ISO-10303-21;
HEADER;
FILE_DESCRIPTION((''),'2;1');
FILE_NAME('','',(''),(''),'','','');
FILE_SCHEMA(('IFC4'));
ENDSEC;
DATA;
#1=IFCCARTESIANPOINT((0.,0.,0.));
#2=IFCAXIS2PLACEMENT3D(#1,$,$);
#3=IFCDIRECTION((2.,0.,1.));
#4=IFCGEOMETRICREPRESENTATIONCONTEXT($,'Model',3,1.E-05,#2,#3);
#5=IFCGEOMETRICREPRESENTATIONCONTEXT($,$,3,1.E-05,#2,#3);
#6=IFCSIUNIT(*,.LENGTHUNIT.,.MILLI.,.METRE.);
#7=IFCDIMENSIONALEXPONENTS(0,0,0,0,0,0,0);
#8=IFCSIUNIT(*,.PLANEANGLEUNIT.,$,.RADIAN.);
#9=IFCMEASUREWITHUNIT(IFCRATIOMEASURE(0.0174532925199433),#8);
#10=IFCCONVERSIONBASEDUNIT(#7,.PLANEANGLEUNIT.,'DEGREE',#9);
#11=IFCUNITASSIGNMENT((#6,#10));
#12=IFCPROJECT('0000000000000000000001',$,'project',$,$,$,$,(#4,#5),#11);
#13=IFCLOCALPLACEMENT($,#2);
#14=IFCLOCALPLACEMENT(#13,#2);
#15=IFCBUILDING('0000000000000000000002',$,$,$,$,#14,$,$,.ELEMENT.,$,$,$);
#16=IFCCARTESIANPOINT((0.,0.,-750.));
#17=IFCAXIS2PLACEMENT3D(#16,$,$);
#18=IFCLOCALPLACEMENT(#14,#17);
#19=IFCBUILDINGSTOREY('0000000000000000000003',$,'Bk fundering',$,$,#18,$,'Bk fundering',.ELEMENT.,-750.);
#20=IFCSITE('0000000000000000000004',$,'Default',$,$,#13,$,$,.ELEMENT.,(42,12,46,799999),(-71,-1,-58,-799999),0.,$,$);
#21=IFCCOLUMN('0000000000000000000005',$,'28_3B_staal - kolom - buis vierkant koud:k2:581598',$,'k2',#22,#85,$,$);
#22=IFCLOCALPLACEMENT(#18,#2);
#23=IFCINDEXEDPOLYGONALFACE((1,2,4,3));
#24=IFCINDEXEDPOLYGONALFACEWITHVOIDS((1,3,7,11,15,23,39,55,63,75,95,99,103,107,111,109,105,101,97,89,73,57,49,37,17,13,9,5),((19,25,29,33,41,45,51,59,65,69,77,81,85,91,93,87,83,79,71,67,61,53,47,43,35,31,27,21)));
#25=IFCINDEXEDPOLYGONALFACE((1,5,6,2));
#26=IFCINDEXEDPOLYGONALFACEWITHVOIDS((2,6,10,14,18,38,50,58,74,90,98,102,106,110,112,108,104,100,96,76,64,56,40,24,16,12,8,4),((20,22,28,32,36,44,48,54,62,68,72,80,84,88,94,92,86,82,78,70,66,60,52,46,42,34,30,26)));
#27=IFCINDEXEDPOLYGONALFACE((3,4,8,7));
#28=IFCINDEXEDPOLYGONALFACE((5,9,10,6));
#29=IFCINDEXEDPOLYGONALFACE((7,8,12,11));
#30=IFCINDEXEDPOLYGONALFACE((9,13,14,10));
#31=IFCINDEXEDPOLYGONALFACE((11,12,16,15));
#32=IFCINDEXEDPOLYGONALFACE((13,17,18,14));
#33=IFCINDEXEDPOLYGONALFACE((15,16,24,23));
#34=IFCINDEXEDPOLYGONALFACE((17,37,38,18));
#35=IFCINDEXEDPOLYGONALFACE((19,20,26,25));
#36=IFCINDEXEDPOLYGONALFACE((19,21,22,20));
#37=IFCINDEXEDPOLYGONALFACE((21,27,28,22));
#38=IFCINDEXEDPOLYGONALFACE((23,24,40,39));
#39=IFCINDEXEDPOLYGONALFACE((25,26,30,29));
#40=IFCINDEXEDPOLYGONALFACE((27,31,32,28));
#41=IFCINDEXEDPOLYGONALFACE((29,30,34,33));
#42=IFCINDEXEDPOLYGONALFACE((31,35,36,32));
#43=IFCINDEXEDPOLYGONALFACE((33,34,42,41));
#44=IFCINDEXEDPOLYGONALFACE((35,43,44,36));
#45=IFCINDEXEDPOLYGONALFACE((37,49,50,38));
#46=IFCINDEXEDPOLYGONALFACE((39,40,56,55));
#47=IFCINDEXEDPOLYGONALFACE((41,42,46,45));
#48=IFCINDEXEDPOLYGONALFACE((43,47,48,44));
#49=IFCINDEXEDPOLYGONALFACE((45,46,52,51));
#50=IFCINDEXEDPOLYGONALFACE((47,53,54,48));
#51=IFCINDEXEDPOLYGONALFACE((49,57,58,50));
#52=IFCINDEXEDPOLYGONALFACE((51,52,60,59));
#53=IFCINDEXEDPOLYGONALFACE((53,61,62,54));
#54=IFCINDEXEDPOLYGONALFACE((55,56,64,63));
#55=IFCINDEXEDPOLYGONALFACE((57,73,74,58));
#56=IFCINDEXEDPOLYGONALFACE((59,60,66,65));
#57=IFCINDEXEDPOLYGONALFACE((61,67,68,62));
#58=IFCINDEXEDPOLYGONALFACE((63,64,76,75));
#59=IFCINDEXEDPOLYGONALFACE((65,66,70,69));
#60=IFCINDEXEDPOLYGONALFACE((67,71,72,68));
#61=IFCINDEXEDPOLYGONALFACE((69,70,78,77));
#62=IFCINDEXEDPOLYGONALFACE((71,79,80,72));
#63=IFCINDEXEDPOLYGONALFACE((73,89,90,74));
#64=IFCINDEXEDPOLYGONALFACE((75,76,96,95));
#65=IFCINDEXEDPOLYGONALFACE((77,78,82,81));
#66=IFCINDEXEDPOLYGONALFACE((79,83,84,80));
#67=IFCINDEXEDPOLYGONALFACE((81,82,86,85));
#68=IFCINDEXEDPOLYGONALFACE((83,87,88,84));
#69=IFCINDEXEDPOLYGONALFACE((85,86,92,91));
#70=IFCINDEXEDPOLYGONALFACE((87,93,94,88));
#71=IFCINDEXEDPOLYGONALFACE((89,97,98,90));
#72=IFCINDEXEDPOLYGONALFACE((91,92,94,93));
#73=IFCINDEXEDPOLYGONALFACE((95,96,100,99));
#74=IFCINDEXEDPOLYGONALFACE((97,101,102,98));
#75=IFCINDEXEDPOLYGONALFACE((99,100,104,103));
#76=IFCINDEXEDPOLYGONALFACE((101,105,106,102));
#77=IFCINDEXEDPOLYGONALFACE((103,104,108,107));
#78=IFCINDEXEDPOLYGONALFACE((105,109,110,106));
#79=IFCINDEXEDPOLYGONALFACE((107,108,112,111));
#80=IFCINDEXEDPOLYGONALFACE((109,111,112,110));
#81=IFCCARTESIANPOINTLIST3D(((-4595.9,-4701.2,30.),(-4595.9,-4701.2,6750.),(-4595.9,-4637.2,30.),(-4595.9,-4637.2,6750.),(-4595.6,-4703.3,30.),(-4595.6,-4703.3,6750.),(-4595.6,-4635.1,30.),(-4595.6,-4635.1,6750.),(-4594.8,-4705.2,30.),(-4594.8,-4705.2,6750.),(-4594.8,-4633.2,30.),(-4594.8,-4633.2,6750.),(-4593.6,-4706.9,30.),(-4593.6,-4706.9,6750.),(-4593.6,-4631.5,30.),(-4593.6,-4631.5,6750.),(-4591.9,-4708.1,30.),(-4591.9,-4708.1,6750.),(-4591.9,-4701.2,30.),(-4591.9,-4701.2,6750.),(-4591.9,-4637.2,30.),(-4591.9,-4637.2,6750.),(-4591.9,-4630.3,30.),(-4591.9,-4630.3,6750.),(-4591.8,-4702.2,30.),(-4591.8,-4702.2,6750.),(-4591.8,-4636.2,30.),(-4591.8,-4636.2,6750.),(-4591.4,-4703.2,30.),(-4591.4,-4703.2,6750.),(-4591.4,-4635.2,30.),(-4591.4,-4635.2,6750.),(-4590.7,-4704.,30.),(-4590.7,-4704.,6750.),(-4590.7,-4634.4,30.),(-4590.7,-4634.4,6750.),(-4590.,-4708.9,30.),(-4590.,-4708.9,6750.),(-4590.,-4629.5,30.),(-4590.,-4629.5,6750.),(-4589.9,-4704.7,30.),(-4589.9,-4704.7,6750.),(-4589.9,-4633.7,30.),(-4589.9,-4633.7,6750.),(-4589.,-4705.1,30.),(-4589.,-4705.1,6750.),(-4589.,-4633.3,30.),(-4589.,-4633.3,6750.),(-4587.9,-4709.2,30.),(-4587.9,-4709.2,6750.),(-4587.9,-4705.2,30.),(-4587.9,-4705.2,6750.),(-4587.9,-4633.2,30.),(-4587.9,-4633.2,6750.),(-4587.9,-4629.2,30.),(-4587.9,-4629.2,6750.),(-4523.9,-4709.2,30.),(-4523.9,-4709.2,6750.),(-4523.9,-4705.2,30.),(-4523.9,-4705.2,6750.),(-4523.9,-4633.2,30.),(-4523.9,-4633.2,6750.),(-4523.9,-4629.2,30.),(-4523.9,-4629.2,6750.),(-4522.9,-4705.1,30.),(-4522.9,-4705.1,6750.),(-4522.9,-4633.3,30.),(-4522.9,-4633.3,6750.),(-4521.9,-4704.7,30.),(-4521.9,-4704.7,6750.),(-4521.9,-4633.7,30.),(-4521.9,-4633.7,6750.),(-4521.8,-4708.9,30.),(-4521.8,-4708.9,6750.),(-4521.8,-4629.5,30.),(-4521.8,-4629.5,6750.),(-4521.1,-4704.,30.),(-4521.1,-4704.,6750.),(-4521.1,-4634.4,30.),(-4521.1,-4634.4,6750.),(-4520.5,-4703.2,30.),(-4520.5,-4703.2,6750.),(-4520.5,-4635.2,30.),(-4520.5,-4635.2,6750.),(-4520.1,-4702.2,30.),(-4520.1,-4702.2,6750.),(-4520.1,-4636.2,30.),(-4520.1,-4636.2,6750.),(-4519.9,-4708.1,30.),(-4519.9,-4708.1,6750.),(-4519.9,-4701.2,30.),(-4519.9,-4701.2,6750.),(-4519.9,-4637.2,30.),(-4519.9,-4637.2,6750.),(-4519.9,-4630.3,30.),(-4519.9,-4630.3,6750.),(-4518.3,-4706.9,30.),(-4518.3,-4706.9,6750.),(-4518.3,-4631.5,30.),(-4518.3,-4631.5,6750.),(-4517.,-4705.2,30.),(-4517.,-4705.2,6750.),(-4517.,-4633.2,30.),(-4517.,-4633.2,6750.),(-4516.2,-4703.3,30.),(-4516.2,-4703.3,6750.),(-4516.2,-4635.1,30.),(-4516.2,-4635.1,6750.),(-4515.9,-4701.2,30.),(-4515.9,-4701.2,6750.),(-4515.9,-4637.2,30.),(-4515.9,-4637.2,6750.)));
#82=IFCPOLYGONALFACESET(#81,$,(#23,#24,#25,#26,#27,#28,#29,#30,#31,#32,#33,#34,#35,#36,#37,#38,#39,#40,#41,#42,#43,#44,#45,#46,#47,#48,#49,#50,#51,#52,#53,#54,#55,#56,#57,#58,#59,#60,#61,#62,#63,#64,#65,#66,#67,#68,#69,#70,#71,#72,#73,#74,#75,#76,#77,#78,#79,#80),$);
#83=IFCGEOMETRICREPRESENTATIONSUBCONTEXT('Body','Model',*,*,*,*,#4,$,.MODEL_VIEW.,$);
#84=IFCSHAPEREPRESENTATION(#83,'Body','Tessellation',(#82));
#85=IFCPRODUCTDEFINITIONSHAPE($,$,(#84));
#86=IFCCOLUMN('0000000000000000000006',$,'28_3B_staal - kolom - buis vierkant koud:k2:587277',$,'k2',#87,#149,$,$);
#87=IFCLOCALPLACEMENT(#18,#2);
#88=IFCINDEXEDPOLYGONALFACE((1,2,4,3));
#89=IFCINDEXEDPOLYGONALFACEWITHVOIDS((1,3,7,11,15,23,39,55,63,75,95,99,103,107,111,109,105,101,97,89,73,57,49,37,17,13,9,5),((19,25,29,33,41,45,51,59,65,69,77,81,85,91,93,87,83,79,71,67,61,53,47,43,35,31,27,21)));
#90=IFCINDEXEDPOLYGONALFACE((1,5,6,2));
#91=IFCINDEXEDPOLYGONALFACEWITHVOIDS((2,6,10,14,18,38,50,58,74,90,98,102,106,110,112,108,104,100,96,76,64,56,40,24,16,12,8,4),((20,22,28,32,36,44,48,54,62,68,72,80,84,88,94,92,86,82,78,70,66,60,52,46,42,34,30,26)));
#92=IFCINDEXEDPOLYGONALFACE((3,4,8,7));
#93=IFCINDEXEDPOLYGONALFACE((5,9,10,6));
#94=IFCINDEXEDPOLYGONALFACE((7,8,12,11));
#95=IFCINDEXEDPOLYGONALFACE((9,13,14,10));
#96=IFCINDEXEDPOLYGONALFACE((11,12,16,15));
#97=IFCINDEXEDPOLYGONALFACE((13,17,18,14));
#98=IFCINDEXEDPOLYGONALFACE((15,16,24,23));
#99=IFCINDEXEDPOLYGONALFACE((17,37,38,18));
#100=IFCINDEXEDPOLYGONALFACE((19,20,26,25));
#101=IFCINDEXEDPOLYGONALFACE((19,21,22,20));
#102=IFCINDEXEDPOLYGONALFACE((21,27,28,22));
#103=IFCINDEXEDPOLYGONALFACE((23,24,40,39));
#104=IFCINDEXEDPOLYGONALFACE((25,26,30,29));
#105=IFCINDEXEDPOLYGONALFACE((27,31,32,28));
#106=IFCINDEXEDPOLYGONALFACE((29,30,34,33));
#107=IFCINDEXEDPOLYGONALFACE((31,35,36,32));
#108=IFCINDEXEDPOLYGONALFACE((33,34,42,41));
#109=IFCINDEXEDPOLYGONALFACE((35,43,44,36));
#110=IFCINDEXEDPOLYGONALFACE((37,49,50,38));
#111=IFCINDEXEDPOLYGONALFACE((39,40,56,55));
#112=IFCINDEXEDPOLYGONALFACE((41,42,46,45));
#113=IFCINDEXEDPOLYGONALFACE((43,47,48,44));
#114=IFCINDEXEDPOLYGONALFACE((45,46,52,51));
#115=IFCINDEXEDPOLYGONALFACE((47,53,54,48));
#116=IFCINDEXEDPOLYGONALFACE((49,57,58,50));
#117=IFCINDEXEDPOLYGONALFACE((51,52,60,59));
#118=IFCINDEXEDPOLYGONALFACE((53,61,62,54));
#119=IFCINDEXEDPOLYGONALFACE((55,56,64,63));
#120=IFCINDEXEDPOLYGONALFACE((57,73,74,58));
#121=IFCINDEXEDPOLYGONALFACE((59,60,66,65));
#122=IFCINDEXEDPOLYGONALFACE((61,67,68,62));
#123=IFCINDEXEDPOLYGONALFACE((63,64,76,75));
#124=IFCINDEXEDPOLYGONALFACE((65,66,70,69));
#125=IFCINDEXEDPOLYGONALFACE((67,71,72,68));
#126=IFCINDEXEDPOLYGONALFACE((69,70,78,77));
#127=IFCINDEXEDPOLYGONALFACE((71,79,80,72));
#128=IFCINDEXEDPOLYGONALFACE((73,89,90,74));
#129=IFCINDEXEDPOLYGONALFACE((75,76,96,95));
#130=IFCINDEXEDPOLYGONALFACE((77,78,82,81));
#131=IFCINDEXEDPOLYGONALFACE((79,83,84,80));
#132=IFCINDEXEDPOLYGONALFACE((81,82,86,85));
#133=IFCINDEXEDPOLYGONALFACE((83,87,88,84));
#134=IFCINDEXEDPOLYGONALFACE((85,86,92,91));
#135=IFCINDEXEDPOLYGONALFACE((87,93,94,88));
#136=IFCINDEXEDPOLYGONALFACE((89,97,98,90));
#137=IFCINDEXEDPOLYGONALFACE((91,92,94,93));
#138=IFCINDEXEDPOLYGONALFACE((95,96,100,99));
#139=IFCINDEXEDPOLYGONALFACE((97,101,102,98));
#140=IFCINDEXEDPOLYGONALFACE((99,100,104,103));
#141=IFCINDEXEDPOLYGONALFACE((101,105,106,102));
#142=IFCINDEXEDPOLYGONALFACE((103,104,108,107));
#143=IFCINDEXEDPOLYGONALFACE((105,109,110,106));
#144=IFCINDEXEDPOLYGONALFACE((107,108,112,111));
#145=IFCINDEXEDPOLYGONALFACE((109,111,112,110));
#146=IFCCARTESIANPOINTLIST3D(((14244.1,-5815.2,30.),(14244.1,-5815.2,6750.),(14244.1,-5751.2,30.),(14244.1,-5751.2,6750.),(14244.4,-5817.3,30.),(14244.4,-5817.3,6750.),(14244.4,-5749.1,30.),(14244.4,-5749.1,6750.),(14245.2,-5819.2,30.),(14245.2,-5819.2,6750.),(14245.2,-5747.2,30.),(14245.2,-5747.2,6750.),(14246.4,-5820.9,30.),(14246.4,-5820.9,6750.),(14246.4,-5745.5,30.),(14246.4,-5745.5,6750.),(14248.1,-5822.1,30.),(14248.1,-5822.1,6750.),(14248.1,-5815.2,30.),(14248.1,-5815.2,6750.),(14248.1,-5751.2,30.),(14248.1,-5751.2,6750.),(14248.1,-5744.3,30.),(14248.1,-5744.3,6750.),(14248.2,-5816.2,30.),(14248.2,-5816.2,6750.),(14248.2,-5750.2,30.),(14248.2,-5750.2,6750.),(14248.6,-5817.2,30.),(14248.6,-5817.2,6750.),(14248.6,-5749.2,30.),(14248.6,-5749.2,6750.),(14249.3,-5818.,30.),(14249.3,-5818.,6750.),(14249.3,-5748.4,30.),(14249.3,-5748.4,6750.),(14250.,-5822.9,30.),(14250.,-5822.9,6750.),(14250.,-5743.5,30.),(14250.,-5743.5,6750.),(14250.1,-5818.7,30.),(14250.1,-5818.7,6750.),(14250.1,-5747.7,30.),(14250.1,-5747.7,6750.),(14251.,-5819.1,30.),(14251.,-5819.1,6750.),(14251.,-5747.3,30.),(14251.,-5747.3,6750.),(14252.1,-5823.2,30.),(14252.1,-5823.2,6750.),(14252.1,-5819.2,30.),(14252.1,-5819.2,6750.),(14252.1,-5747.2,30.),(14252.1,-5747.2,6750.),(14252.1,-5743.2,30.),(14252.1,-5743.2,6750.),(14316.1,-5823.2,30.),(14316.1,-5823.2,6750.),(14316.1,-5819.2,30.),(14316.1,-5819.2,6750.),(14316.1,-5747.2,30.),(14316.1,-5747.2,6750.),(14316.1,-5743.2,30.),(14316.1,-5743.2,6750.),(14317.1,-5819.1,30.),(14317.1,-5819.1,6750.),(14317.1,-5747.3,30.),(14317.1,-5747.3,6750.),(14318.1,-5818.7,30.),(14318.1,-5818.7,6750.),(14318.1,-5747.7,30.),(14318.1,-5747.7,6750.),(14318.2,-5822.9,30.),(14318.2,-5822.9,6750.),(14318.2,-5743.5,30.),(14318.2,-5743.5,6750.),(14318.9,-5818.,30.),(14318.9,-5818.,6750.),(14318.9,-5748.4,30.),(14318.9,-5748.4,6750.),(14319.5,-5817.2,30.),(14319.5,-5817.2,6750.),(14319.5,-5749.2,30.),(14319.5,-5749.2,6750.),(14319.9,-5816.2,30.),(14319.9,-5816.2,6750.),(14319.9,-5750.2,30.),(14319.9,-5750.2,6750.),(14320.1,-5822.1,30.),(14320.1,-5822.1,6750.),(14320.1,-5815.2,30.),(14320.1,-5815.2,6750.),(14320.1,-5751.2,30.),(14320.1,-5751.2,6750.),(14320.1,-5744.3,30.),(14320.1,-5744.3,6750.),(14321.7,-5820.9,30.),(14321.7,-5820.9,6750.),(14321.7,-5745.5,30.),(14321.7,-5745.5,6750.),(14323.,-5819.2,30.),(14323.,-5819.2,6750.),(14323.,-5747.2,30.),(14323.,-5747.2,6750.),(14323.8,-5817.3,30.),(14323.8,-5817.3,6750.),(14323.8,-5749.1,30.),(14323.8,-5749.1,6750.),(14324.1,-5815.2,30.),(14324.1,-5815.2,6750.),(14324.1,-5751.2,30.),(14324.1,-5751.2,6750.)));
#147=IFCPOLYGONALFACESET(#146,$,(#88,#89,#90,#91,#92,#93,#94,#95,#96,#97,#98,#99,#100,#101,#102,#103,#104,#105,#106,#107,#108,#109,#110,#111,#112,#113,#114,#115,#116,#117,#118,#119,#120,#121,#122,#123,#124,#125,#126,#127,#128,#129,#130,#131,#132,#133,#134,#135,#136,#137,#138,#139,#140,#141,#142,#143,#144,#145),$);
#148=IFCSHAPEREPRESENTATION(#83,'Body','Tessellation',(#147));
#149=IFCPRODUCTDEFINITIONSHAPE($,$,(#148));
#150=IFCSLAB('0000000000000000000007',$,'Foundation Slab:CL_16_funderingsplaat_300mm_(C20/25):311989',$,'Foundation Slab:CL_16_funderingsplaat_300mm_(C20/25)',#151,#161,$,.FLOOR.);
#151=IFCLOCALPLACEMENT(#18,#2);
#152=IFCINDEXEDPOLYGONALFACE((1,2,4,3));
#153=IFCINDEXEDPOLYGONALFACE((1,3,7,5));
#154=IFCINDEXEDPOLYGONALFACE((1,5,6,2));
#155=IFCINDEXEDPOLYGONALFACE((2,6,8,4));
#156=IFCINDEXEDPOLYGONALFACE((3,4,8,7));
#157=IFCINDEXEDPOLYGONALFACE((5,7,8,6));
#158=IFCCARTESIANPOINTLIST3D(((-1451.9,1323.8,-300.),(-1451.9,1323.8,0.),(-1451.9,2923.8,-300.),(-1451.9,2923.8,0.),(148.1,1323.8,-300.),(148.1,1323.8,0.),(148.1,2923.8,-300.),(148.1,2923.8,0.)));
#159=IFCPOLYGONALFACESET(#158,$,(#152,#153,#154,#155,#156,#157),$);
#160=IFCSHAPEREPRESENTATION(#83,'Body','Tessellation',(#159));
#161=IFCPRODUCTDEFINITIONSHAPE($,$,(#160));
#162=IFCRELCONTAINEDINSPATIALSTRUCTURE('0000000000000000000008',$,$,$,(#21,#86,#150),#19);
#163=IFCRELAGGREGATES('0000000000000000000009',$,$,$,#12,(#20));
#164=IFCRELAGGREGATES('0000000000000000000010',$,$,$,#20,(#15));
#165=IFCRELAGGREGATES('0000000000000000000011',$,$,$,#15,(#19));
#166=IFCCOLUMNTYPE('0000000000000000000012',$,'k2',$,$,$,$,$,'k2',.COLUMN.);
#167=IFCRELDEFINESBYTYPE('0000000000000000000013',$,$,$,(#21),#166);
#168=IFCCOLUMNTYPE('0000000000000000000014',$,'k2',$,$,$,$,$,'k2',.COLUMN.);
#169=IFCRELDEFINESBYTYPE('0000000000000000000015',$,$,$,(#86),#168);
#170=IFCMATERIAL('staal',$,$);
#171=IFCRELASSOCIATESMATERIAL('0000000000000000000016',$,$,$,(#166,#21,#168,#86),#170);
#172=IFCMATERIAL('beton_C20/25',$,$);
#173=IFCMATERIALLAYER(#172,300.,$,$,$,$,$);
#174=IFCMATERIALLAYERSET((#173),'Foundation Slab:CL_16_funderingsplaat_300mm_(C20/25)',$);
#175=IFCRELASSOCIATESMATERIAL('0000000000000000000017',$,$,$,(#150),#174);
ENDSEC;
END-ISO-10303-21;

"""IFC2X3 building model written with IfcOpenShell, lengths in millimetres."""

from ifc_helpers import new_model, entity, si_unit, converted_unit, direction, frame, frame_2d, origin, place, context, subcontext, project, spatial, polyline, circle_curve, parameter, trimmed, segment, composite_curve, rectangle, outline, extrude, source, transform, mapped, material, layer, layer_set, layer_usage, type_object, type_shapes, element, save


model = new_model("IFC2X3")

# Units and contexts
model_context = context("Model", 3, precision=1e-05, world=origin(), true_north=direction((2.0, 0.0, 1.0)))
context_of_model = context(None, 3, precision=1e-05, world=origin(), true_north=direction((2.0, 0.0, 1.0)))
body_context = subcontext(model_context, "Body", "Model", "MODEL_VIEW")
ifc_project = project(units=[si_unit("LENGTHUNIT", "METRE", prefix="MILLI"), converted_unit("PLANEANGLEUNIT", "DEGREE", entity("IfcRatioMeasure", 0.0174532925199433), si_unit("PLANEANGLEUNIT", "RADIAN"), dimensions=[0, 0, 0, 0, 0, 0, 0])], contexts=[model_context, context_of_model])

# Site, building, storey
site_placement = place(None, origin())
site = spatial("IfcSite", under=ifc_project, at=site_placement, Name="Default", CompositionType="ELEMENT", RefLatitude=(42, 12, 46, 799999), RefLongitude=(-71, -1, -58, -799999), RefElevation=0.0)
building_placement = place(site_placement, origin())
building = spatial("IfcBuilding", under=site, at=building_placement, CompositionType="ELEMENT")
storey_placement = place(building_placement, frame((0.0, 0.0, -750.0)))
storey = spatial("IfcBuildingStorey", under=building, at=storey_placement, Name="Bk fundering", LongName="Bk fundering", CompositionType="ELEMENT", Elevation=-750.0)

# Columns
ifc_material_1 = material(Name="staal")
column_type_1 = type_object("IfcColumnType", Name="k2", ElementType="k2", PredefinedType="COLUMN", material=ifc_material_1)
shared_shape_1 = source(origin(), body_context, "Body", "SweptSolid", [
    extrude(outline(composite_curve([segment(trimmed(circle_curve(frame_2d((32.0, -32.0), x_axis=(1.0, 0.0)), 8.0), [parameter(270.0)], [parameter(0.0)], True, "PARAMETER"), True, "CONTINUOUS"), segment(polyline([(40.0, -32.0), (40.0, 32.0)]), True, "CONTINUOUS"), segment(trimmed(circle_curve(frame_2d((32.0, 32.0), x_axis=(1.0, 0.0)), 8.0), [parameter(0.0)], [parameter(90.0)], True, "PARAMETER"), True, "CONTINUOUS"), segment(polyline([(32.0, 40.0), (-32.0, 40.0)]), True, "CONTINUOUS"), segment(trimmed(circle_curve(frame_2d((-32.0, 32.0), x_axis=(1.0, 0.0)), 8.0), [parameter(90.0)], [parameter(180.0)], True, "PARAMETER"), True, "CONTINUOUS"), segment(polyline([(-40.0, 32.0), (-40.0, -32.0)]), True, "CONTINUOUS"), segment(trimmed(circle_curve(frame_2d((-32.0, -32.0), x_axis=(1.0, 0.0)), 8.0), [parameter(180.0)], [parameter(270.0)], True, "PARAMETER"), True, "CONTINUOUS"), segment(polyline([(-32.0, -40.0), (32.0, -40.0)]), True, "CONTINUOUS")], self_intersect=False), holes=[composite_curve([segment(polyline([(32.0, -36.0), (-32.0, -36.0)]), True, "CONTINUOUS"), segment(trimmed(circle_curve(frame_2d((-32.0, -32.0), x_axis=(1.0, 0.0)), 4.0), [parameter(180.0)], [parameter(270.0)], True, "PARAMETER"), False, "CONTINUOUS"), segment(polyline([(-36.0, -32.0), (-36.0, 32.0)]), True, "CONTINUOUS"), segment(trimmed(circle_curve(frame_2d((-32.0, 32.0), x_axis=(1.0, 0.0)), 4.0), [parameter(90.0)], [parameter(180.0)], True, "PARAMETER"), False, "CONTINUOUS"), segment(polyline([(-32.0, 36.0), (32.0, 36.0)]), True, "CONTINUOUS"), segment(trimmed(circle_curve(frame_2d((32.0, 32.0), x_axis=(1.0, 0.0)), 4.0), [parameter(360.0)], [parameter(90.0)], True, "PARAMETER"), False, "CONTINUOUS"), segment(polyline([(36.0, 32.0), (36.0, -32.0)]), True, "CONTINUOUS"), segment(trimmed(circle_curve(frame_2d((32.0, -32.0), x_axis=(1.0, 0.0)), 4.0), [parameter(270.0)], [parameter(0.0)], True, "PARAMETER"), False, "CONTINUOUS")], self_intersect=False)]), frame((-4555.9, -4669.2, -720.0)), (0.0, 0.0, 1.0), 6720.0),
])
type_shapes(column_type_1, [shared_shape_1])
column_1_placement = place(storey_placement, frame((0.0, 0.0, 750.0)))
element("IfcColumn", 1, at=column_1_placement, inside=storey, type_object=column_type_1, material=ifc_material_1, Name="28_3B_staal - kolom - buis vierkant koud:k2:581598", ObjectType="k2", context=body_context, shape_type="MappedRepresentation", body=[
    mapped(shared_shape_1, transform((0.0, 0.0, 0.0), scale=1.0)),
])
column_type_2 = type_object("IfcColumnType", Name="k2", ElementType="k2", PredefinedType="COLUMN", material=ifc_material_1)
shared_shape_2 = source(origin(), body_context, "Body", "SweptSolid", [
    extrude(outline(composite_curve([segment(polyline([(-32.0, -40.0), (32.0, -40.0)]), True, "CONTINUOUS"), segment(trimmed(circle_curve(frame_2d((32.0, -32.0), x_axis=(-1.0, 0.0)), 8.0), [parameter(90.0)], [parameter(180.0)], True, "PARAMETER"), True, "CONTINUOUS"), segment(polyline([(40.0, -32.0), (40.0, 32.0)]), True, "CONTINUOUS"), segment(trimmed(circle_curve(frame_2d((32.0, 32.0), x_axis=(-1.0, 0.0)), 8.0), [parameter(180.0)], [parameter(270.0)], True, "PARAMETER"), True, "CONTINUOUS"), segment(polyline([(32.0, 40.0), (-32.0, 40.0)]), True, "CONTINUOUS"), segment(trimmed(circle_curve(frame_2d((-32.0, 32.0), x_axis=(-1.0, 0.0)), 8.0), [parameter(270.0)], [parameter(360.0)], True, "PARAMETER"), True, "CONTINUOUS"), segment(polyline([(-40.0, 32.0), (-40.0, -32.0)]), True, "CONTINUOUS"), segment(trimmed(circle_curve(frame_2d((-32.0, -32.0), x_axis=(-1.0, 0.0)), 8.0), [parameter(360.0)], [parameter(90.0)], True, "PARAMETER"), True, "CONTINUOUS")], self_intersect=False), holes=[composite_curve([segment(trimmed(circle_curve(frame_2d((-32.0, -32.0), x_axis=(-1.0, 0.0)), 4.0), [parameter(0.0)], [parameter(90.0)], True, "PARAMETER"), False, "CONTINUOUS"), segment(polyline([(-36.0, -32.0), (-36.0, 32.0)]), True, "CONTINUOUS"), segment(trimmed(circle_curve(frame_2d((-32.0, 32.0), x_axis=(-1.0, 0.0)), 4.0), [parameter(270.0)], [parameter(0.0)], True, "PARAMETER"), False, "CONTINUOUS"), segment(polyline([(-32.0, 36.0), (32.0, 36.0)]), True, "CONTINUOUS"), segment(trimmed(circle_curve(frame_2d((32.0, 32.0), x_axis=(-1.0, 0.0)), 4.0), [parameter(180.0)], [parameter(270.0)], True, "PARAMETER"), False, "CONTINUOUS"), segment(polyline([(36.0, 32.0), (36.0, -32.0)]), True, "CONTINUOUS"), segment(trimmed(circle_curve(frame_2d((32.0, -32.0), x_axis=(-1.0, 0.0)), 4.0), [parameter(90.0)], [parameter(180.0)], True, "PARAMETER"), False, "CONTINUOUS"), segment(polyline([(32.0, -36.0), (-32.0, -36.0)]), True, "CONTINUOUS")], self_intersect=False)]), frame((14284.1, -5783.2, -720.0)), (0.0, 0.0, 1.0), 6720.0),
])
type_shapes(column_type_2, [shared_shape_2])
column_2_placement = place(storey_placement, frame((0.0, 0.0, 750.0)))
element("IfcColumn", 2, at=column_2_placement, inside=storey, type_object=column_type_2, material=ifc_material_1, Name="28_3B_staal - kolom - buis vierkant koud:k2:587277", ObjectType="k2", context=body_context, shape_type="MappedRepresentation", body=[
    mapped(shared_shape_2, transform((0.0, 0.0, 0.0), scale=1.0)),
])

# Slab
ifc_material_2 = material(Name="beton_C20/25")
ifc_layer_1 = layer(ifc_material_2, 300.0)
ifc_layer_set_1 = layer_set([ifc_layer_1], Name="Foundation Slab:CL_16_funderingsplaat_300mm_(C20/25)")
ifc_layer_usage_1 = layer_usage(ifc_layer_set_1, "AXIS3", "POSITIVE", 0.0)
slab_placement = place(storey_placement, origin())
element("IfcSlab", 3, at=slab_placement, inside=storey, material=ifc_layer_usage_1, Name="Foundation Slab:CL_16_funderingsplaat_300mm_(C20/25):311989", ObjectType="Foundation Slab:CL_16_funderingsplaat_300mm_(C20/25)", PredefinedType="FLOOR", context=body_context, shape_type="SweptSolid", body=[
    extrude(rectangle(XDim=1600.0, YDim=1600.0, at=frame_2d((0.0, 0.0), x_axis=(1.0, 0.0))), frame((-651.9, 2123.8, 0.0), z_axis=(0.0, 0.0, -1.0), x_axis=(0.0, 1.0, 0.0)), (0.0, 0.0, 1.0), 300.0),
])

save(model, "model.ifc")
